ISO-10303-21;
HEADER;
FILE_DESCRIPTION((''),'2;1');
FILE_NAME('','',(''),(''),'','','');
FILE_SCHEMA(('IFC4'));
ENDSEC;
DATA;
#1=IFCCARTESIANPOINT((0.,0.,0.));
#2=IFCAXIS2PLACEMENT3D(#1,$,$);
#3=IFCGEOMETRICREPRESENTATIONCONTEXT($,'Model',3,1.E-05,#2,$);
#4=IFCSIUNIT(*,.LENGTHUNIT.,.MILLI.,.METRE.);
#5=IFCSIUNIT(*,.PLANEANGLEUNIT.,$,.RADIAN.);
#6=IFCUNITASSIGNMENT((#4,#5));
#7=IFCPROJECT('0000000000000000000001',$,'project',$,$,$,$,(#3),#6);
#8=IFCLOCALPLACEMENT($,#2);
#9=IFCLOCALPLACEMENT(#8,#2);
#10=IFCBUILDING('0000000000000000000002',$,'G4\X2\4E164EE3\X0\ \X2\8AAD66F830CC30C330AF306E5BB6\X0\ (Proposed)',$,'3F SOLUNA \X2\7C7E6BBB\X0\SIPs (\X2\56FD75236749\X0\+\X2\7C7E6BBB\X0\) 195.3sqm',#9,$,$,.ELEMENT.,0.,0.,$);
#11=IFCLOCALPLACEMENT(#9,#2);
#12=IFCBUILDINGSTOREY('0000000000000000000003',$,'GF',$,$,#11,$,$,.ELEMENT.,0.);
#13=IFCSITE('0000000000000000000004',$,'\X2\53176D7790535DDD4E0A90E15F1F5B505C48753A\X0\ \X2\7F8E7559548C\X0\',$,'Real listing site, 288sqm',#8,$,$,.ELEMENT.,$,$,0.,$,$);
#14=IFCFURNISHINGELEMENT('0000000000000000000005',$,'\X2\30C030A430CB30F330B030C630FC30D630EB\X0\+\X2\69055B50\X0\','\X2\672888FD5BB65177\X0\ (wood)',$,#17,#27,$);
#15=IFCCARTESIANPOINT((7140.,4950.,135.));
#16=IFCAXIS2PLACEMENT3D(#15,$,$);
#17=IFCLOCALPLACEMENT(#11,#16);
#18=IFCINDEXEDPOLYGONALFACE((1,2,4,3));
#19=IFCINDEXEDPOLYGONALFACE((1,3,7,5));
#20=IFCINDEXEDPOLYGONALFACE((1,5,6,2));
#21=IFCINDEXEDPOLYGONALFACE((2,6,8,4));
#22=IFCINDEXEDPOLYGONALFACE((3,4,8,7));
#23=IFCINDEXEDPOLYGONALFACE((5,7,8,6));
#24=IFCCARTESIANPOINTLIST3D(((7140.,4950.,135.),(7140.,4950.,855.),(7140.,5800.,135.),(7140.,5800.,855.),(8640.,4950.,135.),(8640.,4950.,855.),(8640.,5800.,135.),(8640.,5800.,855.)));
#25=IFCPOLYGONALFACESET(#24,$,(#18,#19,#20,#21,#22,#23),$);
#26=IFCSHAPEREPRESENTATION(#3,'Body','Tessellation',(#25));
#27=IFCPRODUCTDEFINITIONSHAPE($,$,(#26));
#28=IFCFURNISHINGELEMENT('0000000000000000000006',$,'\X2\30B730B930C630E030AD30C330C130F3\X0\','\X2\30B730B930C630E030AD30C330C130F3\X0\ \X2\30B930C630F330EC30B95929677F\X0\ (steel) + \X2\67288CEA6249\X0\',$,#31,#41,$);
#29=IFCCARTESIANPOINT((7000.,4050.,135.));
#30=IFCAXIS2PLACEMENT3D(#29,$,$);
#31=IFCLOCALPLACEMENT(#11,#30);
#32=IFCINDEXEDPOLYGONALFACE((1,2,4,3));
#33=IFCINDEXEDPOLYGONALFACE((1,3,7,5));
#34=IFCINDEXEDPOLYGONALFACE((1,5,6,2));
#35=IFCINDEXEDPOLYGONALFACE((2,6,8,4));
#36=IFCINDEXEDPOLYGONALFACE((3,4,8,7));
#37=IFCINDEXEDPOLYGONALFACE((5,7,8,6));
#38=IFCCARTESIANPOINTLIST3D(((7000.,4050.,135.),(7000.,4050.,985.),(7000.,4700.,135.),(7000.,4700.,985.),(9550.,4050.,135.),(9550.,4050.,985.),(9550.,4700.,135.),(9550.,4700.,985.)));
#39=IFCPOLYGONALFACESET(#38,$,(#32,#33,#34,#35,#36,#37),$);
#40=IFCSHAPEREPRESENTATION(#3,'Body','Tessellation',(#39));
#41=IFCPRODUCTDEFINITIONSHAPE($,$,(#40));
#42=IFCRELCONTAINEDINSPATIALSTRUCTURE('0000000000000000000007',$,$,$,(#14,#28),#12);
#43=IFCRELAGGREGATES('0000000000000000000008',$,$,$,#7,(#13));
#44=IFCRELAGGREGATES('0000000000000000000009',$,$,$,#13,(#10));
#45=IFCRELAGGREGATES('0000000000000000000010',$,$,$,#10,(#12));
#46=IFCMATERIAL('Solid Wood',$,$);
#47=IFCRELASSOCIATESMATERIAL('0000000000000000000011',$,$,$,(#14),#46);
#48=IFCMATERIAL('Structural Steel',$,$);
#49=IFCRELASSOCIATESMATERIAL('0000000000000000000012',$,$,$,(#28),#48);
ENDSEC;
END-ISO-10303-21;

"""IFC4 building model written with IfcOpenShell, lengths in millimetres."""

from ifc_helpers import new_model, si_unit, frame, frame_2d, origin, place, context, project, spatial, rectangle, extrude, material, element, save


model = new_model("IFC4")

# Units and contexts
model_context = context("Model", 3, precision=1e-05, world=origin())
ifc_project = project(units=[si_unit("LENGTHUNIT", "METRE", prefix="MILLI"), si_unit("PLANEANGLEUNIT", "RADIAN")], contexts=[model_context])

# Site, building, storey
site_placement = place(None, origin())
site = spatial("IfcSite", under=ifc_project, at=site_placement, Name="北海道川上郡弟子屈町 美留和", ObjectType="Real listing site, 288sqm", CompositionType="ELEMENT", RefElevation=0.0)
building_placement = place(site_placement, origin())
building = spatial("IfcBuilding", under=site, at=building_placement, Name="G4世代 読書ヌックの家 (Proposed)", ObjectType="3F SOLUNA 籾殻SIPs (国産杉+籾殻) 195.3sqm", CompositionType="ELEMENT", ElevationOfRefHeight=0.0, ElevationOfTerrain=0.0)
storey_placement = place(building_placement, origin())
storey = spatial("IfcBuildingStorey", under=building, at=storey_placement, Name="GF", CompositionType="ELEMENT", Elevation=0.0)

# Shared definitions
ifc_material_1 = material(Name="Solid Wood")

# Furnishing elements
furnishing_1_placement = place(storey_placement, frame((7140.0, 4950.0, 135.0)))
element("IfcFurnishingElement", 1, at=furnishing_1_placement, inside=storey, material=ifc_material_1, Name="ダイニングテーブル+椅子", Description="木製家具 (wood)", context=model_context, shape_type="SweptSolid", body=[
    extrude(rectangle(XDim=1500.0, YDim=850.0, at=frame_2d((750.0, 425.0))), frame((7140.0, 4950.0, 135.0)), (0.0, 0.0, 1.0), 720.0),
])
ifc_material_2 = material(Name="Structural Steel")
furnishing_2_placement = place(storey_placement, frame((7000.0, 4050.0, 135.0)))
element("IfcFurnishingElement", 2, at=furnishing_2_placement, inside=storey, material=ifc_material_2, Name="システムキッチン", Description="システムキッチン ステンレス天板 (steel) + 木質扉", context=model_context, shape_type="SweptSolid", body=[
    extrude(rectangle(XDim=2550.0, YDim=650.0, at=frame_2d((1275.0, 325.0))), frame((7000.0, 4050.0, 135.0)), (0.0, 0.0, 1.0), 850.0),
])

save(model, "model.ifc")
